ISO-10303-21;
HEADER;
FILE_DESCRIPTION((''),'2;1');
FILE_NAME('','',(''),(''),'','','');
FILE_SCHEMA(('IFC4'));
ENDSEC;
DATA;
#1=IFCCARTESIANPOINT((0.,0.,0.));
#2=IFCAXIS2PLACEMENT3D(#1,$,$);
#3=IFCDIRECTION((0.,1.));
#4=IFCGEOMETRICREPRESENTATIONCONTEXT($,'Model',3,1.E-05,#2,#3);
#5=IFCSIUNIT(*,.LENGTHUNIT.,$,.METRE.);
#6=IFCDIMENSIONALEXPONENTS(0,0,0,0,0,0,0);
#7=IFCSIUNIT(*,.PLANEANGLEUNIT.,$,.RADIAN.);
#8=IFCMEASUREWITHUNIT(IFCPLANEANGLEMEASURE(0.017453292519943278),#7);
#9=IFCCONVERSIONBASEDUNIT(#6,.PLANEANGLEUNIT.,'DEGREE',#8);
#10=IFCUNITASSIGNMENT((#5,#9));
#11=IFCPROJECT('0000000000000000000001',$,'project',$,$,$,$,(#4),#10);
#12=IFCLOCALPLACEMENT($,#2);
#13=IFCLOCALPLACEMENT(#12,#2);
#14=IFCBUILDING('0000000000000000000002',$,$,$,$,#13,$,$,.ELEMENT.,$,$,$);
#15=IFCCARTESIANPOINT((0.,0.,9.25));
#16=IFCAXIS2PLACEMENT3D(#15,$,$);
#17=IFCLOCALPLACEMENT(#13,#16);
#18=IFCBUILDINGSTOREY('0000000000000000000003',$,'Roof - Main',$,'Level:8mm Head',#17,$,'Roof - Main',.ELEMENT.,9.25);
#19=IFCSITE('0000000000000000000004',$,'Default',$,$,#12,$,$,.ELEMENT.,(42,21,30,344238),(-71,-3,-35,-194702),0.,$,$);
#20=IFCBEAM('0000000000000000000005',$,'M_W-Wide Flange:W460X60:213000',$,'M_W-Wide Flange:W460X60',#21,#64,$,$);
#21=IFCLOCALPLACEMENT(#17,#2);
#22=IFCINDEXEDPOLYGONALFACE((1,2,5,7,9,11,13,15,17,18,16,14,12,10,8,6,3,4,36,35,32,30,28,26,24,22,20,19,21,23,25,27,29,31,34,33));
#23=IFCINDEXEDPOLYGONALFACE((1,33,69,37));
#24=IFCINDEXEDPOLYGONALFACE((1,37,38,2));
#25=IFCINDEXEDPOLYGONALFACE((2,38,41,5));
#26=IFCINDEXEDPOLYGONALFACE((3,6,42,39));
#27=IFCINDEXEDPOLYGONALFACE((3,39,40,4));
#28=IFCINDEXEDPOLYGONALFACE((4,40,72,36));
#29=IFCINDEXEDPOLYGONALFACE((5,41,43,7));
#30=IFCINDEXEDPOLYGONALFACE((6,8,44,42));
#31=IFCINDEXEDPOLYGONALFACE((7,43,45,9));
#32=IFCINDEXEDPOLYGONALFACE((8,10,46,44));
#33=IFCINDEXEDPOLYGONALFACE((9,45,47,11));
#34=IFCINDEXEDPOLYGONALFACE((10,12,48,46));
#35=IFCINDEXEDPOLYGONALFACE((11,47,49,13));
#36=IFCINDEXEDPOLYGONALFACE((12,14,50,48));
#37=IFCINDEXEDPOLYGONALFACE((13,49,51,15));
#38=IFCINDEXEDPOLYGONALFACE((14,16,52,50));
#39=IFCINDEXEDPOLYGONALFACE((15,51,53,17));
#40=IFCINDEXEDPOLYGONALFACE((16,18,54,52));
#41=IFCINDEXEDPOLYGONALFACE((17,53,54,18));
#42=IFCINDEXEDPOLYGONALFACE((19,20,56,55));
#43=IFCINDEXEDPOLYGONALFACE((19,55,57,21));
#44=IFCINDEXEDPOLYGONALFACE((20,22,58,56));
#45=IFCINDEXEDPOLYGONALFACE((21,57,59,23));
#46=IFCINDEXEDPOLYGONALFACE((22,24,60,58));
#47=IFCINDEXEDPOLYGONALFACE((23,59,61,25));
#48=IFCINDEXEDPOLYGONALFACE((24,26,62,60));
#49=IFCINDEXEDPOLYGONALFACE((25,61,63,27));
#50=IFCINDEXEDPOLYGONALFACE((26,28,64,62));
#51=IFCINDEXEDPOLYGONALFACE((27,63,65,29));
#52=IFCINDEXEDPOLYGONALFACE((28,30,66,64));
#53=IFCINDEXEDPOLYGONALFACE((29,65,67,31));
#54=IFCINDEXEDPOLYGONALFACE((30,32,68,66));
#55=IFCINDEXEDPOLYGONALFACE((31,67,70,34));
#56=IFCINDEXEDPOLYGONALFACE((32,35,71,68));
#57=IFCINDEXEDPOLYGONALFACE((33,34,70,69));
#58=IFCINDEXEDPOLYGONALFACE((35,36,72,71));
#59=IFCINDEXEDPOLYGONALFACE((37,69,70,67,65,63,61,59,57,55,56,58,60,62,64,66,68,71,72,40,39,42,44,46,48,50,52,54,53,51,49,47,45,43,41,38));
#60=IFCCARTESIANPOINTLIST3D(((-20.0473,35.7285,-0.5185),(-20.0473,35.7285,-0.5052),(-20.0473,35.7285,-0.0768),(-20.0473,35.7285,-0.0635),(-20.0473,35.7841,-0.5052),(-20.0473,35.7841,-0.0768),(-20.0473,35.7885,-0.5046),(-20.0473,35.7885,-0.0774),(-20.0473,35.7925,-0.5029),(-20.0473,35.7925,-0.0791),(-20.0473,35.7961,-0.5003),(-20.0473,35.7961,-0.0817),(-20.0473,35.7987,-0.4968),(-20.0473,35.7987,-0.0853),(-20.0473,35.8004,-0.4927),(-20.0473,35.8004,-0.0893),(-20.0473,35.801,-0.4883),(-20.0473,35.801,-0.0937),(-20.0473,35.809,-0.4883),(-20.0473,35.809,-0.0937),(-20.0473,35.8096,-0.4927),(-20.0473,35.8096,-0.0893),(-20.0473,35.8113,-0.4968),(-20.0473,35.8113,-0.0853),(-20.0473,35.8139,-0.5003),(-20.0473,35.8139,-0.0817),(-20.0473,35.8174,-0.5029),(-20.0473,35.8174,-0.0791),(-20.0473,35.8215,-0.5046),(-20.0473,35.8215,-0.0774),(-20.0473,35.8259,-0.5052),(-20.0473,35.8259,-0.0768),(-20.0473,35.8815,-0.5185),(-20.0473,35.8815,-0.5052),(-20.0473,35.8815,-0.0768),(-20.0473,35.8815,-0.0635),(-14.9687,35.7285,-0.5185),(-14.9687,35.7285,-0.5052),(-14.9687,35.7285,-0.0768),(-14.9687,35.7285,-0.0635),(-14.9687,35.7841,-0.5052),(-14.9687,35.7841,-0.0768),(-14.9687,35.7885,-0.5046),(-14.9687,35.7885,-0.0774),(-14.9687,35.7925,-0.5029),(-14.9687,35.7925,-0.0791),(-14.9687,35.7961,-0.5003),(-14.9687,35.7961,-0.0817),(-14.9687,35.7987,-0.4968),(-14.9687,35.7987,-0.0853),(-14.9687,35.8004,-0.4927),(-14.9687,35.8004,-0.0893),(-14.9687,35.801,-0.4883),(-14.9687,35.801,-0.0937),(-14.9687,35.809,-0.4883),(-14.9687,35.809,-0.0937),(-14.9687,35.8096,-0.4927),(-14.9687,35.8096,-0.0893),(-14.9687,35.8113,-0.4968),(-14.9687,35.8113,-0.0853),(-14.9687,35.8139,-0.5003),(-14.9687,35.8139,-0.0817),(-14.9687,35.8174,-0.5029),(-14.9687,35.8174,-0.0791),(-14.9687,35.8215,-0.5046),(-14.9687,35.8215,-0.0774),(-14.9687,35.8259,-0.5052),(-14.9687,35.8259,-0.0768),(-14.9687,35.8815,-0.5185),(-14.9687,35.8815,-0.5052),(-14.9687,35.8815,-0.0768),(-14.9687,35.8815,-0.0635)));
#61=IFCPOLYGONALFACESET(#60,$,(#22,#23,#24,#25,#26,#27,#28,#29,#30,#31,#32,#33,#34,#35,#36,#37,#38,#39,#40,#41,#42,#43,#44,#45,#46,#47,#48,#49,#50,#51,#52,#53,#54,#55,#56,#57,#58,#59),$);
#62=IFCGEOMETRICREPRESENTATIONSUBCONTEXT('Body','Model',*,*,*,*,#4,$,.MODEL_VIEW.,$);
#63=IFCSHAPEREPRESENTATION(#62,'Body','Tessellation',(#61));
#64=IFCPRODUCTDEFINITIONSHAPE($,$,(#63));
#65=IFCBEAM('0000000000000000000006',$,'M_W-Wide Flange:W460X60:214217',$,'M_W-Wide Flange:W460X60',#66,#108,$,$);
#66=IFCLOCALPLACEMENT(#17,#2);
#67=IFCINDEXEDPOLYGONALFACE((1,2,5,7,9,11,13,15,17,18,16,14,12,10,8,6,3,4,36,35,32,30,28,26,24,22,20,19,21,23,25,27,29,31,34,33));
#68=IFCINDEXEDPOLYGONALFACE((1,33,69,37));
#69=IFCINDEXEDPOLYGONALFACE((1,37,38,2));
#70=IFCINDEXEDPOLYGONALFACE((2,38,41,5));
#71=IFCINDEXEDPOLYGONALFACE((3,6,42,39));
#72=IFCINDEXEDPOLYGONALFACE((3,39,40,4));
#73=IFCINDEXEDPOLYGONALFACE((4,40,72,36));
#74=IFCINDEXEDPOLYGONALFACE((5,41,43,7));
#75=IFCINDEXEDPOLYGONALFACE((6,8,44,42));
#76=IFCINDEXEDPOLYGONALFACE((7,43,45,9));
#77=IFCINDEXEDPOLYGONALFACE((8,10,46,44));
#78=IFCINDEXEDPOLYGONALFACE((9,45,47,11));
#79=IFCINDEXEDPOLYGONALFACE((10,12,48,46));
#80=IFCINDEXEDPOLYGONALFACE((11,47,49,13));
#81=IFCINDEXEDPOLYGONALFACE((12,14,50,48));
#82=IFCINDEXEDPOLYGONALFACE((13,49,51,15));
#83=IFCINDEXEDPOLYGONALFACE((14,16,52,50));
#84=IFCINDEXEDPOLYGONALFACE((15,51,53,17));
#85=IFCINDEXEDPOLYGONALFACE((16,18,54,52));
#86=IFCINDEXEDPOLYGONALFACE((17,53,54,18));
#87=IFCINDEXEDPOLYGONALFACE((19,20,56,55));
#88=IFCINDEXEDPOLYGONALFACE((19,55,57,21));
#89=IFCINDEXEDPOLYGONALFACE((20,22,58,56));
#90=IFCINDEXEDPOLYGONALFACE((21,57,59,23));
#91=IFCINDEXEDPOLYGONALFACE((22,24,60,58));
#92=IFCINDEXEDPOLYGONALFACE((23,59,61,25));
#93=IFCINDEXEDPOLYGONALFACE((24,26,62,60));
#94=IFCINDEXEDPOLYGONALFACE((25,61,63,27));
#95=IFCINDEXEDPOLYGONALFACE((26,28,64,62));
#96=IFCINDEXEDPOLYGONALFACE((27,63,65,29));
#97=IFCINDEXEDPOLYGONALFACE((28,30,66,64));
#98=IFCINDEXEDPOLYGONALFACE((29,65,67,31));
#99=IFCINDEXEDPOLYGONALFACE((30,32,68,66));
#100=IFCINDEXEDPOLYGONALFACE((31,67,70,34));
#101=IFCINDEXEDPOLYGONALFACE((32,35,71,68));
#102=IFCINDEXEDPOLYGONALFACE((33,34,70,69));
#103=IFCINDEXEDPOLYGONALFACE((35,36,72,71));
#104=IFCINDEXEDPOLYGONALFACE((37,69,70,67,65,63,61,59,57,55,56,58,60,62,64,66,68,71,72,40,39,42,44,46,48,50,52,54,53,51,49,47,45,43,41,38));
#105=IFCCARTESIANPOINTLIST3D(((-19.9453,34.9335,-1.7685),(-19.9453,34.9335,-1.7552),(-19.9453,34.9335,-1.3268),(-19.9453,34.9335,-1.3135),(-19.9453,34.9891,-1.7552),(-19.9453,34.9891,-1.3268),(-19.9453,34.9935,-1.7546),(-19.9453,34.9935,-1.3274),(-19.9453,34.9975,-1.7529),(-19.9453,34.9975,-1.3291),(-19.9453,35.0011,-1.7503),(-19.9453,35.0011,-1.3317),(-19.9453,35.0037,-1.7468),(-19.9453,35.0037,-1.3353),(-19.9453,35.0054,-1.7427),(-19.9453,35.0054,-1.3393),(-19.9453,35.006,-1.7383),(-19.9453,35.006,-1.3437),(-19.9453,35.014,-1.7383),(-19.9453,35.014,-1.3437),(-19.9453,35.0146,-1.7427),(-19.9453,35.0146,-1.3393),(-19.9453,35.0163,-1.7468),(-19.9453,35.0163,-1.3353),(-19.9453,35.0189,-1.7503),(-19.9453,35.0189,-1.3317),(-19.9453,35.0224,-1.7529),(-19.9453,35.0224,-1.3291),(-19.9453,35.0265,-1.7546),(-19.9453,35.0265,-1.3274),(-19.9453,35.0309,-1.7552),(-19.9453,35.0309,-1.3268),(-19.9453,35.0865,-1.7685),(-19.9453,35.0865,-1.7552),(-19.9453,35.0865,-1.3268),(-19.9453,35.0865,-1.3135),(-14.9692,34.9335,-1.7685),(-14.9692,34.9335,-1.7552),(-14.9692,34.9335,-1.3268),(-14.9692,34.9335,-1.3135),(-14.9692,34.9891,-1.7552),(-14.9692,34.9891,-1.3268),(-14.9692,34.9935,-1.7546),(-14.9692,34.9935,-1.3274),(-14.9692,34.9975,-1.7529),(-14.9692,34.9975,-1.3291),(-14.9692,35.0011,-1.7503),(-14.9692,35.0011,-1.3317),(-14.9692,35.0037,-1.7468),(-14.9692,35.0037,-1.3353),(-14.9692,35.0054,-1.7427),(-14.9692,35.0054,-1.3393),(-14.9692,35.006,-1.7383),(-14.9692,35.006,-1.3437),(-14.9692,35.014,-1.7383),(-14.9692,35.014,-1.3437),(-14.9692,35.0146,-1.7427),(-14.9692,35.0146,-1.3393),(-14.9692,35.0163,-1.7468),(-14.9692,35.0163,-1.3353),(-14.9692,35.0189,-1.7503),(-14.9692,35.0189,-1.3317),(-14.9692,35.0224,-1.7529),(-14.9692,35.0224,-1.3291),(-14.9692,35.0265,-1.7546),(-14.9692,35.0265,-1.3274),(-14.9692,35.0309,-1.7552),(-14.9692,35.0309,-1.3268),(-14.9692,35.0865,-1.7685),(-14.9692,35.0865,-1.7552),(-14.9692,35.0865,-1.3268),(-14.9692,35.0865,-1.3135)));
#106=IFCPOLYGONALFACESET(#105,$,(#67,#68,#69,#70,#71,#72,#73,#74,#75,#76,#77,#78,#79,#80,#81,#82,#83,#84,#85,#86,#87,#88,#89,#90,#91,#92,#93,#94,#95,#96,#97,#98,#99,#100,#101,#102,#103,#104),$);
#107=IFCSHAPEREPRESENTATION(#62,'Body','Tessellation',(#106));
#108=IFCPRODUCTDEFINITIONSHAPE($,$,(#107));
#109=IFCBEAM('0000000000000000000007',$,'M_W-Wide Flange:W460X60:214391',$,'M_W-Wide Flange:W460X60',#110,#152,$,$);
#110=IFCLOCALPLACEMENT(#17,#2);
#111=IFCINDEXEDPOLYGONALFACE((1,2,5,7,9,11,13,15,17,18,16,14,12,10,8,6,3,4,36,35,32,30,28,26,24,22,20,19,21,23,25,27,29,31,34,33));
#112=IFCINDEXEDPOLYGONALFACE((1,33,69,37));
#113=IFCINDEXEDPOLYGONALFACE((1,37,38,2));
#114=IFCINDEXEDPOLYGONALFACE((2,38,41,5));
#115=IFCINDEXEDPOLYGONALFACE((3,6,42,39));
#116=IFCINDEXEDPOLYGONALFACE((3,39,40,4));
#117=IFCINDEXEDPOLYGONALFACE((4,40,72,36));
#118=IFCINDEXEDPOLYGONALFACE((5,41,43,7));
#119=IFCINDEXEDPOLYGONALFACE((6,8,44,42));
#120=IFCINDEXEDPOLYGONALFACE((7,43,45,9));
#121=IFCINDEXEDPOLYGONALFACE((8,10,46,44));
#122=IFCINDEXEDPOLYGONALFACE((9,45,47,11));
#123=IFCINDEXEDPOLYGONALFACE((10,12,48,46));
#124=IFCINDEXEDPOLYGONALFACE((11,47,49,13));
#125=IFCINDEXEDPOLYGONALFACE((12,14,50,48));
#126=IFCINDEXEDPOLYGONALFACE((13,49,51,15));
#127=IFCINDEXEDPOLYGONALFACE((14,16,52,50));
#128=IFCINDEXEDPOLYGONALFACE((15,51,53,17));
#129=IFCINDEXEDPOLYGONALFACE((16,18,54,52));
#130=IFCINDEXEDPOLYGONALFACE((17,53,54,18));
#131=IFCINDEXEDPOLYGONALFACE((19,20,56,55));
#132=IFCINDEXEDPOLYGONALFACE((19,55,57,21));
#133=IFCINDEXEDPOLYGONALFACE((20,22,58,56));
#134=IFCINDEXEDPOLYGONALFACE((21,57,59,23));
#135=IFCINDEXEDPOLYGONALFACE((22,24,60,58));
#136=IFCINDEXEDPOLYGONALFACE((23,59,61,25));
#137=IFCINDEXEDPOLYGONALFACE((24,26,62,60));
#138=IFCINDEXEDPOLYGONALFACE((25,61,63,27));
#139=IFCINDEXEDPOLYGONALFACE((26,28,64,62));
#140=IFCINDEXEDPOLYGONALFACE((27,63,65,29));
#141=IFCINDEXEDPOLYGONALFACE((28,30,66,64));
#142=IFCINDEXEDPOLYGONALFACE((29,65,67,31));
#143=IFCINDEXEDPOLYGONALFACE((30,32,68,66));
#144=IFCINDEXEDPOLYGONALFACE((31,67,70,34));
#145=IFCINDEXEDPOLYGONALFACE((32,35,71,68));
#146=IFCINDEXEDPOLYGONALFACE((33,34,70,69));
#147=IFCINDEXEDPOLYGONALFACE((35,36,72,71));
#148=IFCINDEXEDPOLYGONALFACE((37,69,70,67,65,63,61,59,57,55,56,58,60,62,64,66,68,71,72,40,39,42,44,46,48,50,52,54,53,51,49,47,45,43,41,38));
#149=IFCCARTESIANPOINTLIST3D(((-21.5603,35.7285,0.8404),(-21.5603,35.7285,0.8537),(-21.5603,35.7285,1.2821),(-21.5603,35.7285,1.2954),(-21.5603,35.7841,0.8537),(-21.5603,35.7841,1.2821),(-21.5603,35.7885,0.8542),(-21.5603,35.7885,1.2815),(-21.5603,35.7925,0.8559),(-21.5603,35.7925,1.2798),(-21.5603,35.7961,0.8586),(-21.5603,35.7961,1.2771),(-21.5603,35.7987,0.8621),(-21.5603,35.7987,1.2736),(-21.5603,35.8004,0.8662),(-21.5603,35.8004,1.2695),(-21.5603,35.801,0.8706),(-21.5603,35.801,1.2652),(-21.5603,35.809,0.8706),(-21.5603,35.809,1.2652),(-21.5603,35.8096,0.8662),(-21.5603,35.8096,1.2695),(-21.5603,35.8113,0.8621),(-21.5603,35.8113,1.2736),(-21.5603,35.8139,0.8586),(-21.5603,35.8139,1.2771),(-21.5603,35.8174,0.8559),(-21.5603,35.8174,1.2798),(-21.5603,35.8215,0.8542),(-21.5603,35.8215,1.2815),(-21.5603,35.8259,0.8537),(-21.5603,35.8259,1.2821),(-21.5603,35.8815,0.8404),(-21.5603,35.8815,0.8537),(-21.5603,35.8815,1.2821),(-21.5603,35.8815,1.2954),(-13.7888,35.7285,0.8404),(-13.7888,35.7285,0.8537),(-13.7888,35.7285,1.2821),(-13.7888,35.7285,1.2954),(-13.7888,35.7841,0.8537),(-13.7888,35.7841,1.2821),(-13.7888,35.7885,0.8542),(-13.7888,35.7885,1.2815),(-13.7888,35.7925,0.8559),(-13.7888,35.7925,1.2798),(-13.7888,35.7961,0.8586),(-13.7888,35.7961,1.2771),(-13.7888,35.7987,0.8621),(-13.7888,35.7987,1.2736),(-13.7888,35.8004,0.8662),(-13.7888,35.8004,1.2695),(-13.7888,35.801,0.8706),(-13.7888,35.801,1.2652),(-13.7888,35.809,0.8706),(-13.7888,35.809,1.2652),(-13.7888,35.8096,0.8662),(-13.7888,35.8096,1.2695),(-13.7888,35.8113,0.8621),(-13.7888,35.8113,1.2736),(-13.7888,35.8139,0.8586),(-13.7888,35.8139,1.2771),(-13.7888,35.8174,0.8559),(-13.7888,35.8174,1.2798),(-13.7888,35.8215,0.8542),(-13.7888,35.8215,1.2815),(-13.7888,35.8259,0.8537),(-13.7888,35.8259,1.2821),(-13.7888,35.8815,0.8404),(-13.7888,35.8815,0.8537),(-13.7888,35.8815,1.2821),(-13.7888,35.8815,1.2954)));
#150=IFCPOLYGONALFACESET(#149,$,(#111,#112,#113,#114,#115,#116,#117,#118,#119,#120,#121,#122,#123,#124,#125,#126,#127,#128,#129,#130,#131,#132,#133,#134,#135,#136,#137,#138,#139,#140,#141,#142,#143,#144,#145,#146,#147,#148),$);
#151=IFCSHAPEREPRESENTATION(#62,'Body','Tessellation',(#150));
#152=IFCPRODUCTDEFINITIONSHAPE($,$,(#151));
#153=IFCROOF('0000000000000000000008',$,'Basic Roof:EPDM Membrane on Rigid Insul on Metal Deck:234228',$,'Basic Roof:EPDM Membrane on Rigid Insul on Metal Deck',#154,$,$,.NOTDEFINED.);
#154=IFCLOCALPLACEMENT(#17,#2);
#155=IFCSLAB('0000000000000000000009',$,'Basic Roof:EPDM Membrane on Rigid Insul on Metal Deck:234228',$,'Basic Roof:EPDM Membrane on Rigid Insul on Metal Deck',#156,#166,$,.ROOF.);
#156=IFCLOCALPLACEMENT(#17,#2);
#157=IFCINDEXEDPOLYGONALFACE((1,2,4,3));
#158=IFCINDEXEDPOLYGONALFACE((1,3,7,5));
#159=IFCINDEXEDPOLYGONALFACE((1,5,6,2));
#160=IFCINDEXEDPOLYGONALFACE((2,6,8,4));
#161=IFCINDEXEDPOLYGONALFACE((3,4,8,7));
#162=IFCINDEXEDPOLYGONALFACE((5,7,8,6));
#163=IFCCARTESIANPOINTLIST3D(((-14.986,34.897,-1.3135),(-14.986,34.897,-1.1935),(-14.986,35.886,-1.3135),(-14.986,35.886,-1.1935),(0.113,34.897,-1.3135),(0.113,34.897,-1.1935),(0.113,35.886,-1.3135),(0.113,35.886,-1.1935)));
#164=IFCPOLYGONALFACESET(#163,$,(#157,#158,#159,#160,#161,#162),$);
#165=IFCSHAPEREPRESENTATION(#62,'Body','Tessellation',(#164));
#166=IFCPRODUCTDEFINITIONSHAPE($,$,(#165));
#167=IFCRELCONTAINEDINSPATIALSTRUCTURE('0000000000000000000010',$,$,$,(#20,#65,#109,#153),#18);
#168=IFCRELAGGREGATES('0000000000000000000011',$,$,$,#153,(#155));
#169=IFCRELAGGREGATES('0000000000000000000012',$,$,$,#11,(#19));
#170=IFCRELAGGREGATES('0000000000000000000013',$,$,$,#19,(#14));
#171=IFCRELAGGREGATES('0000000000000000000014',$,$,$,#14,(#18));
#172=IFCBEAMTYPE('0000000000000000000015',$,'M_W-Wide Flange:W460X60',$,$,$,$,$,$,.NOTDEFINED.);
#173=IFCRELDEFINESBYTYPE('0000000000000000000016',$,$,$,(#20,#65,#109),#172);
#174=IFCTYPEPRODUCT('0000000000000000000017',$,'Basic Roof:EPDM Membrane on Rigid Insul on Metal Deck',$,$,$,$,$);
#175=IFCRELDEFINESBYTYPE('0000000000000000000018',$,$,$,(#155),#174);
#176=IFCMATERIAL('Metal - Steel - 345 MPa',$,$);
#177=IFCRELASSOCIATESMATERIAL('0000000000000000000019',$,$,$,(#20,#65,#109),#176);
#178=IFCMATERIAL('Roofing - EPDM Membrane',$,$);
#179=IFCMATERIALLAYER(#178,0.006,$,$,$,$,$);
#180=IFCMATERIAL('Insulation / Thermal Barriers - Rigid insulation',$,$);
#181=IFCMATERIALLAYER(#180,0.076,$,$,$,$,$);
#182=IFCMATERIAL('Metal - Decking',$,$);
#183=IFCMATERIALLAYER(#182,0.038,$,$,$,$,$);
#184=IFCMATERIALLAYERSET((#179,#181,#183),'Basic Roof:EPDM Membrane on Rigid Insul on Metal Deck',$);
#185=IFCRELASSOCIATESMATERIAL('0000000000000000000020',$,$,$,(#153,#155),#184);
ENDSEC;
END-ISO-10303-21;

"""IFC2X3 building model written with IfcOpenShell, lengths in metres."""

from ifc_helpers import new_model, entity, si_unit, converted_unit, direction, frame, frame_2d, origin, place, context, subcontext, project, spatial, rectangle, i_section, extrude, material, layer, layer_set, type_object, element, aggregate, save


model = new_model("IFC2X3")

# Units and contexts
model_context = context("Model", 3, precision=1e-05, world=origin(), true_north=direction((0.0, 1.0)))
body_context = subcontext(model_context, "Body", "Model", "MODEL_VIEW")
ifc_project = project(units=[si_unit("LENGTHUNIT", "METRE"), converted_unit("PLANEANGLEUNIT", "DEGREE", entity("IfcPlaneAngleMeasure", 0.017453292519943278), si_unit("PLANEANGLEUNIT", "RADIAN"), dimensions=[0, 0, 0, 0, 0, 0, 0])], contexts=[model_context])

# Site, building, storey
site_placement = place(None, origin())
site = spatial("IfcSite", under=ifc_project, at=site_placement, Name="Default", CompositionType="ELEMENT", RefLatitude=(42, 21, 30, 344238), RefLongitude=(-71, -3, -35, -194702), RefElevation=0.0)
building_placement = place(site_placement, origin())
building = spatial("IfcBuilding", under=site, at=building_placement, CompositionType="ELEMENT")
storey_placement = place(building_placement, frame((0.0, 0.0, 9.25)))
storey = spatial("IfcBuildingStorey", under=building, at=storey_placement, Name="Roof - Main", ObjectType="Level:8mm Head", LongName="Roof - Main", CompositionType="ELEMENT", Elevation=9.25)

# Shared definitions
ifc_material_1 = material(Name="Metal - Steel - 345 MPa")

# Beams
beam_type_1 = type_object("IfcBeamType", Name="M_W-Wide Flange:W460X60", PredefinedType="NOTDEFINED")
beam_1_placement = place(storey_placement, frame((-20.06, 35.805, -0.0635)))
element("IfcBeam", 1, at=beam_1_placement, inside=storey, type_object=beam_type_1, material=ifc_material_1, Name="M_W-Wide Flange:W460X60:213000", ObjectType="M_W-Wide Flange:W460X60", context=body_context, shape_type="SweptSolid", body=[
    extrude(i_section(OverallWidth=0.153, OverallDepth=0.455, WebThickness=0.008, FlangeThickness=0.0133, FilletRadius=0.0169, at=frame_2d((0.0, 0.0), x_axis=(0.0, 1.0))), frame((0.0127, 0.0, -0.2275), z_axis=(1.0, 0.0, 0.0), x_axis=(0.0, 0.0, -1.0)), (0.0, 0.0, 1.0), 5.0786),
])
beam_2_placement = place(storey_placement, frame((-14.88, 35.01, -1.3135), z_axis=(0.0, 0.0, 1.0), x_axis=(-1.0, 0.0, 0.0)))
element("IfcBeam", 2, at=beam_2_placement, inside=storey, type_object=beam_type_1, material=ifc_material_1, Name="M_W-Wide Flange:W460X60:214217", ObjectType="M_W-Wide Flange:W460X60", context=body_context, shape_type="SweptSolid", body=[
    extrude(i_section(OverallWidth=0.153, OverallDepth=0.455, WebThickness=0.008, FlangeThickness=0.0133, FilletRadius=0.0169, at=frame_2d((0.0, 0.0), x_axis=(0.0, 1.0))), frame((0.0892, 0.0, -0.2275), z_axis=(1.0, 0.0, 0.0), x_axis=(0.0, 0.0, -1.0)), (0.0, 0.0, 1.0), 4.9761),
])
beam_3_placement = place(storey_placement, frame((-21.649, 35.805, 1.2954)))
element("IfcBeam", 3, at=beam_3_placement, inside=storey, type_object=beam_type_1, material=ifc_material_1, Name="M_W-Wide Flange:W460X60:214391", ObjectType="M_W-Wide Flange:W460X60", context=body_context, shape_type="SweptSolid", body=[
    extrude(i_section(OverallWidth=0.153, OverallDepth=0.455, WebThickness=0.008, FlangeThickness=0.0133, FilletRadius=0.0169, at=frame_2d((0.0, 0.0), x_axis=(0.0, 1.0))), frame((0.0887, 0.0, -0.2275), z_axis=(1.0, 0.0, 0.0), x_axis=(0.0, 0.0, -1.0)), (0.0, 0.0, 1.0), 7.7715),
])

# Roof, slab
ifc_material_2 = material(Name="Roofing - EPDM Membrane")
ifc_layer_1 = layer(ifc_material_2, 0.006)
ifc_material_3 = material(Name="Insulation / Thermal Barriers - Rigid insulation")
ifc_layer_2 = layer(ifc_material_3, 0.076)
ifc_material_4 = material(Name="Metal - Decking")
ifc_layer_3 = layer(ifc_material_4, 0.038)
ifc_layer_set = layer_set([ifc_layer_1, ifc_layer_2, ifc_layer_3], Name="Basic Roof:EPDM Membrane on Rigid Insul on Metal Deck")
roof_placement = place(storey_placement, frame((-14.986, 34.897, -1.3135)))
roof = element("IfcRoof", 4, at=roof_placement, inside=storey, material=ifc_layer_set, Name="Basic Roof:EPDM Membrane on Rigid Insul on Metal Deck:234228", ObjectType="Basic Roof:EPDM Membrane on Rigid Insul on Metal Deck", ShapeType="NOTDEFINED")
type_product_1 = type_object("IfcTypeProduct", Name="Basic Roof:EPDM Membrane on Rigid Insul on Metal Deck")
slab_placement = place(roof_placement, origin())
slab = element("IfcSlab", 5, at=slab_placement, type_object=type_product_1, material=ifc_layer_set, Name="Basic Roof:EPDM Membrane on Rigid Insul on Metal Deck:234228", ObjectType="Basic Roof:EPDM Membrane on Rigid Insul on Metal Deck", PredefinedType="ROOF", context=body_context, shape_type="SweptSolid", body=[
    extrude(rectangle(XDim=15.099, YDim=0.989, at=frame_2d((0.0, 0.0), x_axis=(-1.0, 0.0))), frame((7.5495, 0.4945, 0.0)), (0.0, 0.0, 1.0), 0.12),
])
aggregate(roof, [slab])

save(model, "model.ifc")
